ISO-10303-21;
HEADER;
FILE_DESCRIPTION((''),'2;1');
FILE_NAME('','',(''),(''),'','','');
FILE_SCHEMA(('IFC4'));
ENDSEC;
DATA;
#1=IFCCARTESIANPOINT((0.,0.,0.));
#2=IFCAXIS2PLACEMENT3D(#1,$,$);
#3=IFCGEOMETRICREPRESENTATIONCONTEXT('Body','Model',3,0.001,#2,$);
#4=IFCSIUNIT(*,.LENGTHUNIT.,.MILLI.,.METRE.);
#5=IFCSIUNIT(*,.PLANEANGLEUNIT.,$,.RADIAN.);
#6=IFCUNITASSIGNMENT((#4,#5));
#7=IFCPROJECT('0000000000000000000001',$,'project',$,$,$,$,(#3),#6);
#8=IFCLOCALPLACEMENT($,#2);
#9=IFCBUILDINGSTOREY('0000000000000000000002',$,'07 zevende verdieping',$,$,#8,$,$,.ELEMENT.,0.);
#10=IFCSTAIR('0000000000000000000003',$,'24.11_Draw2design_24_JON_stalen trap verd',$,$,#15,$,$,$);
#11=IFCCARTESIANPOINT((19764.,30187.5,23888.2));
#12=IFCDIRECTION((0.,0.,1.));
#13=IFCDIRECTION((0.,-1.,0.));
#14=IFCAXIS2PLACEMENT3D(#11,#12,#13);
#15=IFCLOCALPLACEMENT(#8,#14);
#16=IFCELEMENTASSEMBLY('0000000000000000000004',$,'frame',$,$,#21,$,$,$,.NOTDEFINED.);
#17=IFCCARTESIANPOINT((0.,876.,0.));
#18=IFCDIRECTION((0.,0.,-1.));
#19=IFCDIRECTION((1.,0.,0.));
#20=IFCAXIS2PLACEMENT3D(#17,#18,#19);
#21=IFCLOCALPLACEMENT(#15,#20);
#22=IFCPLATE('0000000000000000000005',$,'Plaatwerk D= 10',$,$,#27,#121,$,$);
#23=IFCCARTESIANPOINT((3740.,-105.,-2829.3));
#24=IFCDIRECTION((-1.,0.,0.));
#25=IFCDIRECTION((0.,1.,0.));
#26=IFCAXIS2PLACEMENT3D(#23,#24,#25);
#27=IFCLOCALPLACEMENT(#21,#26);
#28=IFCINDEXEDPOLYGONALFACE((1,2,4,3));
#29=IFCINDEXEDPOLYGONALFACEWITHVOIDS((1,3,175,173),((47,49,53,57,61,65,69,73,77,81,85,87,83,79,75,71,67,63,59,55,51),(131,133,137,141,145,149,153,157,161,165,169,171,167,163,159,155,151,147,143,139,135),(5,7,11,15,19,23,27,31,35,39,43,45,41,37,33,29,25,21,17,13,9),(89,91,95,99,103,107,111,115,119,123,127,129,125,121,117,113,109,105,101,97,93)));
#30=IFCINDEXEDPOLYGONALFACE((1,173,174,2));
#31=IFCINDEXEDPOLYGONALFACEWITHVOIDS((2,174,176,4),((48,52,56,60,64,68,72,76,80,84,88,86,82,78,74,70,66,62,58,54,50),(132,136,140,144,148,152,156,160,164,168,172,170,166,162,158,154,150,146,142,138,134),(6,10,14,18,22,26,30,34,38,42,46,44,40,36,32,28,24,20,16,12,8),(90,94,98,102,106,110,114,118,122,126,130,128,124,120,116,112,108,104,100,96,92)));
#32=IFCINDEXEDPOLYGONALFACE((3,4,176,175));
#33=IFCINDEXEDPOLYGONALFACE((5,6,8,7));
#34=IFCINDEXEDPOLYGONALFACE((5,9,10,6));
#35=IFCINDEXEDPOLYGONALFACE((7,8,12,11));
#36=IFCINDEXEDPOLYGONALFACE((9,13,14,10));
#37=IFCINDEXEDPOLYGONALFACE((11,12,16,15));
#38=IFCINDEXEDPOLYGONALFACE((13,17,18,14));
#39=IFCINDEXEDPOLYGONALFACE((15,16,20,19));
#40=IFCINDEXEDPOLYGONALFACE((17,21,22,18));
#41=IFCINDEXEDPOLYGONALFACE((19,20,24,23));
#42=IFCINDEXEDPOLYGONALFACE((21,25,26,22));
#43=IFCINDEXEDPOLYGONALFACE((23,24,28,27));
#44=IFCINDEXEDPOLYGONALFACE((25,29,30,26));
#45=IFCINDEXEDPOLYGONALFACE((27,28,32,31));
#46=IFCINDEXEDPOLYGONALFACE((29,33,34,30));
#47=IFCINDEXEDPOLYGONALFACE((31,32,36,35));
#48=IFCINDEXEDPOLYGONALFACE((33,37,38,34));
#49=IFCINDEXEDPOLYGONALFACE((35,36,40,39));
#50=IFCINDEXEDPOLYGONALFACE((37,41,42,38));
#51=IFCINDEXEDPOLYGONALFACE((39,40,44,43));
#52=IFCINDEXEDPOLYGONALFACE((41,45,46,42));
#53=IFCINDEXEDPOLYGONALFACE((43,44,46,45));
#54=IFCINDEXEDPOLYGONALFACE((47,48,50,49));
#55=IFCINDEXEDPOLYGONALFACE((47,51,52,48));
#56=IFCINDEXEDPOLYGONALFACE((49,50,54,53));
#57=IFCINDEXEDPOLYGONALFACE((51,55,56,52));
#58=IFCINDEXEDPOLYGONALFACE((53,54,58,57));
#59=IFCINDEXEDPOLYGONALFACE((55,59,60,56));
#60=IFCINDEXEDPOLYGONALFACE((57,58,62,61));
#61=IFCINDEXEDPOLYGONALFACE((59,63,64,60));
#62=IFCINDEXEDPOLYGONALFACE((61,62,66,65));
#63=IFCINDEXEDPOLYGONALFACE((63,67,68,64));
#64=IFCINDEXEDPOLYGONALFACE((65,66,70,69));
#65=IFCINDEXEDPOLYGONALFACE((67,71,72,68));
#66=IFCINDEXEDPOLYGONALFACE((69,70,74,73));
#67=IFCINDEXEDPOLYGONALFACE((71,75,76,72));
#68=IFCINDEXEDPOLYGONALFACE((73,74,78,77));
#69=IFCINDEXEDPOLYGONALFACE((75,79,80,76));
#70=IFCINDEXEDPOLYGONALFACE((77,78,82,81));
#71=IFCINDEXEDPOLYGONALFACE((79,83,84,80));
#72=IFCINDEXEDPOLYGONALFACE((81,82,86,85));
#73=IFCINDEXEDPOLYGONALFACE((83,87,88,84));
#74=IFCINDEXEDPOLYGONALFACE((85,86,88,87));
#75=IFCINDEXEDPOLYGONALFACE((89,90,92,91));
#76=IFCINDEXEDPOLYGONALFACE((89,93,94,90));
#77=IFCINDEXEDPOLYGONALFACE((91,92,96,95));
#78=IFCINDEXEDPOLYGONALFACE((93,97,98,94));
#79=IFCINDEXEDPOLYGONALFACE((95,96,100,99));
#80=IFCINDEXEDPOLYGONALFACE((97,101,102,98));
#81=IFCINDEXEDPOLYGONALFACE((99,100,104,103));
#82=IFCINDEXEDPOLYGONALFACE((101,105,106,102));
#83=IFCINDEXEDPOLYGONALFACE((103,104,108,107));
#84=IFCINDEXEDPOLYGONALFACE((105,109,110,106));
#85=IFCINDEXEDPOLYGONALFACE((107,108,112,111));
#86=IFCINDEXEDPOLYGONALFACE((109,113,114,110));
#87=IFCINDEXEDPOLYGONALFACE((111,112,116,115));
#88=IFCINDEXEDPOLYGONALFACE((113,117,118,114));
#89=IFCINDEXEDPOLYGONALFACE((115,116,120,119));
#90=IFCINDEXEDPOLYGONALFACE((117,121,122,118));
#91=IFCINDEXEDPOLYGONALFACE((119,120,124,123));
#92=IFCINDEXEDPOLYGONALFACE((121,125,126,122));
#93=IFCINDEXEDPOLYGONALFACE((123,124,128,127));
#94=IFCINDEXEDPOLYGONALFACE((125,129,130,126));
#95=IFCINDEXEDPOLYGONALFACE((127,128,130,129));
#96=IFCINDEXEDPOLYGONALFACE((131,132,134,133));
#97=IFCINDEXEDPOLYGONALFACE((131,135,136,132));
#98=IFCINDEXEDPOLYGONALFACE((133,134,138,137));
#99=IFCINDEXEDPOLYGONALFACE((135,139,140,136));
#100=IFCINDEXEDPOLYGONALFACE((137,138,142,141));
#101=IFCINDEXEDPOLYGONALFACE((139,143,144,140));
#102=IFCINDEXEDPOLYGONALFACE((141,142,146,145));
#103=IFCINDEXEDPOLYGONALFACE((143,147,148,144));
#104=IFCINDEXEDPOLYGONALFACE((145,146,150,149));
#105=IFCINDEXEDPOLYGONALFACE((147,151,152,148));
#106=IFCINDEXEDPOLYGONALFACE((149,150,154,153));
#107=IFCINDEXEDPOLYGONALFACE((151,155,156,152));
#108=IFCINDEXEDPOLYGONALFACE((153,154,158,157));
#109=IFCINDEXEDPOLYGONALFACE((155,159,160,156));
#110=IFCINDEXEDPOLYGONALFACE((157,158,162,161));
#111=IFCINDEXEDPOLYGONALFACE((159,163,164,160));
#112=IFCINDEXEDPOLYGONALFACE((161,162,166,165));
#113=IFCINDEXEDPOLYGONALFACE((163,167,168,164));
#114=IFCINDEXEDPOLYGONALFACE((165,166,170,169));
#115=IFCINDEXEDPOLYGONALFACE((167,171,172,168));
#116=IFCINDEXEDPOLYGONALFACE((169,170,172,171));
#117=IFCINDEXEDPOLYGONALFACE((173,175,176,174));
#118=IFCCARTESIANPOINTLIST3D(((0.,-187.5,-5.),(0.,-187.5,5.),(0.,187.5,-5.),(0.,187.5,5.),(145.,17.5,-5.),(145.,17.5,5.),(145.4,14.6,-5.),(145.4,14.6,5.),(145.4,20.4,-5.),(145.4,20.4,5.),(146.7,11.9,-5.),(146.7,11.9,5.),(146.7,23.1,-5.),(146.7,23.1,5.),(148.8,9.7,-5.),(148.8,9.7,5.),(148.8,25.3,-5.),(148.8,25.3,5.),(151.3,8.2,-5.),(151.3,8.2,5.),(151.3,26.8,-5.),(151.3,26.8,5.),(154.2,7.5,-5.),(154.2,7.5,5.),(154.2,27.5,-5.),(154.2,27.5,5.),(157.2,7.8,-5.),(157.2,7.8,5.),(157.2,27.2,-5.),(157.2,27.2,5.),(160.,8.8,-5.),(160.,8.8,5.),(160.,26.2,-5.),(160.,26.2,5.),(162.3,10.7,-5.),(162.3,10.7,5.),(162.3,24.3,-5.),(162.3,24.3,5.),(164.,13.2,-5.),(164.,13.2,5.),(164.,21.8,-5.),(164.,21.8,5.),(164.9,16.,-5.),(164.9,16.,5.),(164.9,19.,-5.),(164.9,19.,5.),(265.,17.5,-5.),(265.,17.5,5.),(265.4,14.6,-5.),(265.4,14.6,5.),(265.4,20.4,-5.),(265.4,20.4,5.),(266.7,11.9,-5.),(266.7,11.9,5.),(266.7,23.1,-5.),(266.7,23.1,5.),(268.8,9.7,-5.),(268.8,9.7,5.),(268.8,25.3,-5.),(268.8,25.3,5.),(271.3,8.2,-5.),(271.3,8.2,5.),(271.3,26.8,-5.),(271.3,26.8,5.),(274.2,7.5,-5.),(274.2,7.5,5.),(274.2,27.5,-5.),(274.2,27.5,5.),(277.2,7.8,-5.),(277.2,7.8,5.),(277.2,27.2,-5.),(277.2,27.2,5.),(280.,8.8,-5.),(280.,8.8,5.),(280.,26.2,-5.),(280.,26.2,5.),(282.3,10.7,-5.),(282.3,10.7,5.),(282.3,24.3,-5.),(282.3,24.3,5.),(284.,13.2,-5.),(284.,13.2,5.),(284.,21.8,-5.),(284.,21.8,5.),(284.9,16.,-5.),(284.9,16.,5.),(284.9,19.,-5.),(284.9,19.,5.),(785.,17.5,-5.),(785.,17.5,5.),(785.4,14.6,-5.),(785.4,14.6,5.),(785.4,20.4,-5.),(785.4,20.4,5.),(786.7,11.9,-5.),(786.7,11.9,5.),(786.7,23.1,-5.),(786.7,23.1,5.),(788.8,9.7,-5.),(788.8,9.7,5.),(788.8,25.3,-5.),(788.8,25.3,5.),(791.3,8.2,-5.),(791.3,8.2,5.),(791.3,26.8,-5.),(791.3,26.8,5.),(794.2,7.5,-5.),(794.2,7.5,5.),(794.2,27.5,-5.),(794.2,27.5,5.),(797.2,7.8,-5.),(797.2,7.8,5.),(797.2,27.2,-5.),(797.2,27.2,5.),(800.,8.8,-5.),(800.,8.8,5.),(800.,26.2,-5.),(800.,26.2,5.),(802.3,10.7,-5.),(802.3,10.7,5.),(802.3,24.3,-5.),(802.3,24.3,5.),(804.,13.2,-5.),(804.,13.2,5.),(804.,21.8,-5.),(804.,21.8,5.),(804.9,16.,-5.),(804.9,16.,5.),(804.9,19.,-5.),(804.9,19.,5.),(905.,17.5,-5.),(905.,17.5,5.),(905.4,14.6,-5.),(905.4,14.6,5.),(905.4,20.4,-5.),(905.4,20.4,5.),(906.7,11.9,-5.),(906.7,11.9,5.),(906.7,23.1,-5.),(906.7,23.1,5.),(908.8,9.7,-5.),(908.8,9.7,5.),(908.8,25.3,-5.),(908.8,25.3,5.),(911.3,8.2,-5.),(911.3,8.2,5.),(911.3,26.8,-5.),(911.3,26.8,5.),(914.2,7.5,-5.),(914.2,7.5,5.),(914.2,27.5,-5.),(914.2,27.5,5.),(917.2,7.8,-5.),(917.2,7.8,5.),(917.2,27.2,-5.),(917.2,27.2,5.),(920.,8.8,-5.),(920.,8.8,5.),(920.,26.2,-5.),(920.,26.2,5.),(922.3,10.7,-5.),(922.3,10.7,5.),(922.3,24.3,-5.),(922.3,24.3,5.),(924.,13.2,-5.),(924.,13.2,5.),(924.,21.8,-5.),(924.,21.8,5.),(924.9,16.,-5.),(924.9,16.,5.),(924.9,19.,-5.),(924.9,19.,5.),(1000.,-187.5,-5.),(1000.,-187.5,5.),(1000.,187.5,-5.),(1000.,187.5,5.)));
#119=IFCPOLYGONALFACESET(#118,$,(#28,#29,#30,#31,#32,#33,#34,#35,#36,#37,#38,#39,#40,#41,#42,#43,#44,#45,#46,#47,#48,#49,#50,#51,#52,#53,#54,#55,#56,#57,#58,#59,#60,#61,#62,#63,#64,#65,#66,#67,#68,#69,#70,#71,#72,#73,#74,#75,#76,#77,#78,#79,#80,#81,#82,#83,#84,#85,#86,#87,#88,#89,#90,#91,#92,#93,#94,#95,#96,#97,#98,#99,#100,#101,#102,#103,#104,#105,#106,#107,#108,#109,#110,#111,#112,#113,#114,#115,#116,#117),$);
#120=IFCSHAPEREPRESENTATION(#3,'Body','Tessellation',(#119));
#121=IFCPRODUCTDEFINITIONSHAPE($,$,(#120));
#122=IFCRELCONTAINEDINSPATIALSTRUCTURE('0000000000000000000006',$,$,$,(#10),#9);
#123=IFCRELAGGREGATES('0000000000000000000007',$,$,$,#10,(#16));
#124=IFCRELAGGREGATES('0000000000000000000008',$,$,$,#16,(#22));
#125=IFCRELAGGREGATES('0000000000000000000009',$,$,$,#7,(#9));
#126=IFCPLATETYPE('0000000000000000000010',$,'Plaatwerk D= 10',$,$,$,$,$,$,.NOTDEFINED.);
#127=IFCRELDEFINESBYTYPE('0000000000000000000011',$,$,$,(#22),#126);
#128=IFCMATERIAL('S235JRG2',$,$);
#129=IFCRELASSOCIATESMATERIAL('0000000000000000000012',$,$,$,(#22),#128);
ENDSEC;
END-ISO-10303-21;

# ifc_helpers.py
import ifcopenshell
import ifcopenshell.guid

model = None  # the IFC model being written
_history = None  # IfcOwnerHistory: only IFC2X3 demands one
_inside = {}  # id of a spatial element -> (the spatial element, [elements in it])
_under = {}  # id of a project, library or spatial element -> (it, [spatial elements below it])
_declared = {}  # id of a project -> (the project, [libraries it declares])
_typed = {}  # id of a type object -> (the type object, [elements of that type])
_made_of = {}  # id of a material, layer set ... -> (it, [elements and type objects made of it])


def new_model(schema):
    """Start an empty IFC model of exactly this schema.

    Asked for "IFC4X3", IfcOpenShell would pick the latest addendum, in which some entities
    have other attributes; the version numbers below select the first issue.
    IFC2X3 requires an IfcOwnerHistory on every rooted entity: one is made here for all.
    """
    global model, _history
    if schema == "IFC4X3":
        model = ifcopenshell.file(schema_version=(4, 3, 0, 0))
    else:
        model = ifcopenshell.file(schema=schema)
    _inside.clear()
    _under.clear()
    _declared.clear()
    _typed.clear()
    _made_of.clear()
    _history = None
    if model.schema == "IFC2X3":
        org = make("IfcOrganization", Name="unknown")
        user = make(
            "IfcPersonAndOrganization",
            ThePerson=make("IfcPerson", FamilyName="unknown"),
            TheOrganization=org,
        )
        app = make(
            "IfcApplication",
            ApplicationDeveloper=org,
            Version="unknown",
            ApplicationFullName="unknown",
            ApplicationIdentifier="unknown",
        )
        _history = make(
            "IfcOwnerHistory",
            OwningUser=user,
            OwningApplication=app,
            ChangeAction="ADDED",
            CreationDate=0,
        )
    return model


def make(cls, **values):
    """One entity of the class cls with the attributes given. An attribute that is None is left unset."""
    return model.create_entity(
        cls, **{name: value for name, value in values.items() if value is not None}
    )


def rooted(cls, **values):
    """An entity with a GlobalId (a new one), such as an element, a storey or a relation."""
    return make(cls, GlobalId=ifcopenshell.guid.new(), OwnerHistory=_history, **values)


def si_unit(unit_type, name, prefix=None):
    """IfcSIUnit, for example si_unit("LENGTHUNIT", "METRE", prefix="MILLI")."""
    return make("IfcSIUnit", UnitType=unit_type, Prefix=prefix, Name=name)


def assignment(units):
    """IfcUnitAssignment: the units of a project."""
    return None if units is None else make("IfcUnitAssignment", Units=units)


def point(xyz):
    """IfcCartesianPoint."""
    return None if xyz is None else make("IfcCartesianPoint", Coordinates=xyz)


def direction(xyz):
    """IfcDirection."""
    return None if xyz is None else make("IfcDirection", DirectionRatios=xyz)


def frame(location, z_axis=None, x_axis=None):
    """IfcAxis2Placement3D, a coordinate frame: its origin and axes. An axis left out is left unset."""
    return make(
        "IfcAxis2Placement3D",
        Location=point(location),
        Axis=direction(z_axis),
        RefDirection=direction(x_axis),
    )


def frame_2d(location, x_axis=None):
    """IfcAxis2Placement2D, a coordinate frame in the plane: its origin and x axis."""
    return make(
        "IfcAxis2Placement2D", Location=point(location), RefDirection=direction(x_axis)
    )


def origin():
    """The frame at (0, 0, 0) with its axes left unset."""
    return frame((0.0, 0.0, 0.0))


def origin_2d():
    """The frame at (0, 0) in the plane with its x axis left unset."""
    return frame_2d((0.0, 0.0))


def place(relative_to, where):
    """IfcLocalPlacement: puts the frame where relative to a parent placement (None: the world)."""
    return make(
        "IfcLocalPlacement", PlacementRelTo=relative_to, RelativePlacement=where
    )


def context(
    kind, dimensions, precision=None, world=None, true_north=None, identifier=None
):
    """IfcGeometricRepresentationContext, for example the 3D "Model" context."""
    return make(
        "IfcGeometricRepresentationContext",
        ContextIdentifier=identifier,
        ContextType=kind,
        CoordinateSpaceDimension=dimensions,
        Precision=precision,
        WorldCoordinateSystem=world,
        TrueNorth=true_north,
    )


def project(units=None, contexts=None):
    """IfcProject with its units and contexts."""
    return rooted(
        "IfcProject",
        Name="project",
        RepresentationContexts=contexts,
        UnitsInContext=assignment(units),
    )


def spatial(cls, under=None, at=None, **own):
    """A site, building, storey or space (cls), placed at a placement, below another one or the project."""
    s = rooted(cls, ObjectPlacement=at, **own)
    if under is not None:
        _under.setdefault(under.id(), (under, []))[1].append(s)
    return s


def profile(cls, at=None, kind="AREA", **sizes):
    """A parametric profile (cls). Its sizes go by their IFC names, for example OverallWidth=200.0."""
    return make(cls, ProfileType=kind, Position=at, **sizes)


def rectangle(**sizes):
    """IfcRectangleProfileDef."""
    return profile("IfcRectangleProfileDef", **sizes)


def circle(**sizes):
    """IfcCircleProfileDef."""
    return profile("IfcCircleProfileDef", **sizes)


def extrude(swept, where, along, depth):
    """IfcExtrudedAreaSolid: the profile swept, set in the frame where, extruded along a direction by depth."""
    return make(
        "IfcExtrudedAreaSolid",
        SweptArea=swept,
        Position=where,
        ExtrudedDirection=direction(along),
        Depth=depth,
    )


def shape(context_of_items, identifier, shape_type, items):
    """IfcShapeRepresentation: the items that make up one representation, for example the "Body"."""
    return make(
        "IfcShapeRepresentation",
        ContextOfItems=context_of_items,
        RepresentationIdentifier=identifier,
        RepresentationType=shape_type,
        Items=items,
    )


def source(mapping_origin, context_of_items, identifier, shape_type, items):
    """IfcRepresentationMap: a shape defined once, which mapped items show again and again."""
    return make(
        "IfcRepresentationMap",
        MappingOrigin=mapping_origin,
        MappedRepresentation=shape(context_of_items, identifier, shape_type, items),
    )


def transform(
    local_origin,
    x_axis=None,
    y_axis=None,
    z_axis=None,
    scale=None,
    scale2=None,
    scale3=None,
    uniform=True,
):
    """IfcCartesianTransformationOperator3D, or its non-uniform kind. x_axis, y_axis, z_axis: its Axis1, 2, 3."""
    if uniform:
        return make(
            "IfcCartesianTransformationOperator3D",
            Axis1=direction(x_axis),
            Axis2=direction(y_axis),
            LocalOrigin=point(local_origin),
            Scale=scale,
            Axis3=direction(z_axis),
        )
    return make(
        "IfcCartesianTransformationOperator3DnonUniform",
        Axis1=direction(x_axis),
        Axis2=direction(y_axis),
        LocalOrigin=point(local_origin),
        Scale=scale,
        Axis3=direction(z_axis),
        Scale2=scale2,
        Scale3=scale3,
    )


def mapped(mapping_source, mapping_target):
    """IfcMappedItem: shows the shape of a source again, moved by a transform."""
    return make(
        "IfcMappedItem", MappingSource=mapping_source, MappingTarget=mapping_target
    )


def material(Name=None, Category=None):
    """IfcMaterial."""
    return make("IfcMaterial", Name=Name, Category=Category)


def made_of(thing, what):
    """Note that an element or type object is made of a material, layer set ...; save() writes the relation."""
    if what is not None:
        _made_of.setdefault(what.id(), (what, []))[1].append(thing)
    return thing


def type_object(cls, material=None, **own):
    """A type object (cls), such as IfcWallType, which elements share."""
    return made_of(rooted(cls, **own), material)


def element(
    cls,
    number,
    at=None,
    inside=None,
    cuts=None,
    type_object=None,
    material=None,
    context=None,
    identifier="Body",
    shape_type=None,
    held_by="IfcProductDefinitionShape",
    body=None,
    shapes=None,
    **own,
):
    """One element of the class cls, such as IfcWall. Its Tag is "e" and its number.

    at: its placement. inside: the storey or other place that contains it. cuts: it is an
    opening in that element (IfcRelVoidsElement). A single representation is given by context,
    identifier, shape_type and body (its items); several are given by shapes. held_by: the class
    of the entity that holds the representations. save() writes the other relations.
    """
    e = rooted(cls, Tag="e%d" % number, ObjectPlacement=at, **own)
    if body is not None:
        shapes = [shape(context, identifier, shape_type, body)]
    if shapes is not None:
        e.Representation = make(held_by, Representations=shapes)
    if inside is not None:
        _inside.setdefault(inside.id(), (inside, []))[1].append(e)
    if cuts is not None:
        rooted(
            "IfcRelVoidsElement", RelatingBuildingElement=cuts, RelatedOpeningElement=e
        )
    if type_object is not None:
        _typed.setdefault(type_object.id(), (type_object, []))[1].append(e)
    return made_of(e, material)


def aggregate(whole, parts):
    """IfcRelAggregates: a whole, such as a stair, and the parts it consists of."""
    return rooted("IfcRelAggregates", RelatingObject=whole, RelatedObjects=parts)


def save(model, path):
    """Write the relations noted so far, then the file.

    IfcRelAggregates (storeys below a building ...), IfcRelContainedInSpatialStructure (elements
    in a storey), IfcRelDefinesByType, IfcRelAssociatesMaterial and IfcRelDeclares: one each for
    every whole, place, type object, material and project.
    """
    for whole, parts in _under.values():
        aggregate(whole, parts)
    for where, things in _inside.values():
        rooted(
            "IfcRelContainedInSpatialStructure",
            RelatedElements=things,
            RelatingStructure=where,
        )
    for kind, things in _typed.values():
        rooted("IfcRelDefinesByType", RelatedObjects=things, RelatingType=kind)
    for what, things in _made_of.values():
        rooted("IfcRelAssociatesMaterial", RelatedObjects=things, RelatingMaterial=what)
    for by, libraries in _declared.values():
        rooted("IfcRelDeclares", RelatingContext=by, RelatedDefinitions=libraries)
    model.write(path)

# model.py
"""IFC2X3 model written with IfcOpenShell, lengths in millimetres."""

from ifc_helpers import new_model, si_unit, frame, origin, origin_2d, place, context, project, spatial, rectangle, circle, extrude, source, transform, mapped, material, type_object, element, aggregate, save


model = new_model("IFC2X3")

# Units and contexts
model_context = context("Model", 3, precision=0.001, world=origin(), identifier="Body")
ifc_project = project(units=[si_unit("LENGTHUNIT", "METRE", prefix="MILLI"), si_unit("PLANEANGLEUNIT", "RADIAN")], contexts=[model_context])

# Storey
storey_placement = place(None, origin())
storey = spatial("IfcBuildingStorey", under=ifc_project, at=storey_placement, Name="07 zevende verdieping", CompositionType="ELEMENT", Elevation=0.0)

# Stair, element assembly
stair_placement = place(storey_placement, frame((19764.0, 30187.5, 23888.2), z_axis=(0.0, 0.0, 1.0), x_axis=(0.0, -1.0, 0.0)))
stair = element("IfcStair", 1, at=stair_placement, inside=storey, Name="24.11_Draw2design_24_JON_stalen trap verd")
ifc_material_1 = material(Name="S235JRG2")
assembly_1_placement = place(stair_placement, frame((0.0, 876.0, 0.0), z_axis=(0.0, 0.0, -1.0), x_axis=(1.0, 0.0, 0.0)))
assembly_1 = element("IfcElementAssembly", 2, at=assembly_1_placement, Name="frame", PredefinedType="NOTDEFINED")
aggregate(stair, [assembly_1])

# Plate, openings
plate_type = type_object("IfcPlateType", Name="Plaatwerk D= 10")
shared_shape_1 = source(origin(), model_context, "Body", "SweptSolid", [
    extrude(rectangle(XDim=1000.0, YDim=375.0, at=origin_2d()), frame((500.0, 0.0, -5.0)), (0.0, 0.0, 1.0), 10.0),
])
plate_placement = place(assembly_1_placement, frame((3740.0, -105.0, -2829.3), z_axis=(-1.0, 0.0, 0.0), x_axis=(0.0, 1.0, 0.0)))
plate = element("IfcPlate", 3, at=plate_placement, type_object=plate_type, material=ifc_material_1, Name="Plaatwerk D= 10", context=model_context, shape_type="MappedRepresentation", body=[
    mapped(shared_shape_1, transform((0.0, 0.0, 0.0), scale=1.0)),
])
opening_1_placement = place(plate_placement, frame((795.0, 17.5, -5.0), z_axis=(0.0, 0.0, 1.0), x_axis=(-1.0, 0.0, 0.0)))
element("IfcOpeningElement", 4, at=opening_1_placement, cuts=plate, ObjectType="Opening", context=model_context, shape_type="SweptSolid", body=[
    extrude(circle(Radius=10.0, at=origin_2d()), origin(), (0.0, 0.0, 1.0), 10.0),
])
opening_2_placement = place(plate_placement, frame((915.0, 17.5, -5.0), z_axis=(0.0, 0.0, 1.0), x_axis=(-1.0, 0.0, 0.0)))
element("IfcOpeningElement", 5, at=opening_2_placement, cuts=plate, ObjectType="Opening", context=model_context, shape_type="SweptSolid", body=[
    extrude(circle(Radius=10.0, at=origin_2d()), origin(), (0.0, 0.0, 1.0), 10.0),
])
opening_3_placement = place(plate_placement, frame((155.0, 17.5, -5.0), z_axis=(0.0, 0.0, 1.0), x_axis=(-1.0, 0.0, 0.0)))
element("IfcOpeningElement", 6, at=opening_3_placement, cuts=plate, ObjectType="Opening", context=model_context, shape_type="SweptSolid", body=[
    extrude(circle(Radius=10.0, at=origin_2d()), origin(), (0.0, 0.0, 1.0), 10.0),
])
opening_4_placement = place(plate_placement, frame((275.0, 17.5, -5.0), z_axis=(0.0, 0.0, 1.0), x_axis=(-1.0, 0.0, 0.0)))
element("IfcOpeningElement", 7, at=opening_4_placement, cuts=plate, ObjectType="Opening", context=model_context, shape_type="SweptSolid", body=[
    extrude(circle(Radius=10.0, at=origin_2d()), origin(), (0.0, 0.0, 1.0), 10.0),
])
aggregate(assembly_1, [plate])

save(model, "model.ifc")
